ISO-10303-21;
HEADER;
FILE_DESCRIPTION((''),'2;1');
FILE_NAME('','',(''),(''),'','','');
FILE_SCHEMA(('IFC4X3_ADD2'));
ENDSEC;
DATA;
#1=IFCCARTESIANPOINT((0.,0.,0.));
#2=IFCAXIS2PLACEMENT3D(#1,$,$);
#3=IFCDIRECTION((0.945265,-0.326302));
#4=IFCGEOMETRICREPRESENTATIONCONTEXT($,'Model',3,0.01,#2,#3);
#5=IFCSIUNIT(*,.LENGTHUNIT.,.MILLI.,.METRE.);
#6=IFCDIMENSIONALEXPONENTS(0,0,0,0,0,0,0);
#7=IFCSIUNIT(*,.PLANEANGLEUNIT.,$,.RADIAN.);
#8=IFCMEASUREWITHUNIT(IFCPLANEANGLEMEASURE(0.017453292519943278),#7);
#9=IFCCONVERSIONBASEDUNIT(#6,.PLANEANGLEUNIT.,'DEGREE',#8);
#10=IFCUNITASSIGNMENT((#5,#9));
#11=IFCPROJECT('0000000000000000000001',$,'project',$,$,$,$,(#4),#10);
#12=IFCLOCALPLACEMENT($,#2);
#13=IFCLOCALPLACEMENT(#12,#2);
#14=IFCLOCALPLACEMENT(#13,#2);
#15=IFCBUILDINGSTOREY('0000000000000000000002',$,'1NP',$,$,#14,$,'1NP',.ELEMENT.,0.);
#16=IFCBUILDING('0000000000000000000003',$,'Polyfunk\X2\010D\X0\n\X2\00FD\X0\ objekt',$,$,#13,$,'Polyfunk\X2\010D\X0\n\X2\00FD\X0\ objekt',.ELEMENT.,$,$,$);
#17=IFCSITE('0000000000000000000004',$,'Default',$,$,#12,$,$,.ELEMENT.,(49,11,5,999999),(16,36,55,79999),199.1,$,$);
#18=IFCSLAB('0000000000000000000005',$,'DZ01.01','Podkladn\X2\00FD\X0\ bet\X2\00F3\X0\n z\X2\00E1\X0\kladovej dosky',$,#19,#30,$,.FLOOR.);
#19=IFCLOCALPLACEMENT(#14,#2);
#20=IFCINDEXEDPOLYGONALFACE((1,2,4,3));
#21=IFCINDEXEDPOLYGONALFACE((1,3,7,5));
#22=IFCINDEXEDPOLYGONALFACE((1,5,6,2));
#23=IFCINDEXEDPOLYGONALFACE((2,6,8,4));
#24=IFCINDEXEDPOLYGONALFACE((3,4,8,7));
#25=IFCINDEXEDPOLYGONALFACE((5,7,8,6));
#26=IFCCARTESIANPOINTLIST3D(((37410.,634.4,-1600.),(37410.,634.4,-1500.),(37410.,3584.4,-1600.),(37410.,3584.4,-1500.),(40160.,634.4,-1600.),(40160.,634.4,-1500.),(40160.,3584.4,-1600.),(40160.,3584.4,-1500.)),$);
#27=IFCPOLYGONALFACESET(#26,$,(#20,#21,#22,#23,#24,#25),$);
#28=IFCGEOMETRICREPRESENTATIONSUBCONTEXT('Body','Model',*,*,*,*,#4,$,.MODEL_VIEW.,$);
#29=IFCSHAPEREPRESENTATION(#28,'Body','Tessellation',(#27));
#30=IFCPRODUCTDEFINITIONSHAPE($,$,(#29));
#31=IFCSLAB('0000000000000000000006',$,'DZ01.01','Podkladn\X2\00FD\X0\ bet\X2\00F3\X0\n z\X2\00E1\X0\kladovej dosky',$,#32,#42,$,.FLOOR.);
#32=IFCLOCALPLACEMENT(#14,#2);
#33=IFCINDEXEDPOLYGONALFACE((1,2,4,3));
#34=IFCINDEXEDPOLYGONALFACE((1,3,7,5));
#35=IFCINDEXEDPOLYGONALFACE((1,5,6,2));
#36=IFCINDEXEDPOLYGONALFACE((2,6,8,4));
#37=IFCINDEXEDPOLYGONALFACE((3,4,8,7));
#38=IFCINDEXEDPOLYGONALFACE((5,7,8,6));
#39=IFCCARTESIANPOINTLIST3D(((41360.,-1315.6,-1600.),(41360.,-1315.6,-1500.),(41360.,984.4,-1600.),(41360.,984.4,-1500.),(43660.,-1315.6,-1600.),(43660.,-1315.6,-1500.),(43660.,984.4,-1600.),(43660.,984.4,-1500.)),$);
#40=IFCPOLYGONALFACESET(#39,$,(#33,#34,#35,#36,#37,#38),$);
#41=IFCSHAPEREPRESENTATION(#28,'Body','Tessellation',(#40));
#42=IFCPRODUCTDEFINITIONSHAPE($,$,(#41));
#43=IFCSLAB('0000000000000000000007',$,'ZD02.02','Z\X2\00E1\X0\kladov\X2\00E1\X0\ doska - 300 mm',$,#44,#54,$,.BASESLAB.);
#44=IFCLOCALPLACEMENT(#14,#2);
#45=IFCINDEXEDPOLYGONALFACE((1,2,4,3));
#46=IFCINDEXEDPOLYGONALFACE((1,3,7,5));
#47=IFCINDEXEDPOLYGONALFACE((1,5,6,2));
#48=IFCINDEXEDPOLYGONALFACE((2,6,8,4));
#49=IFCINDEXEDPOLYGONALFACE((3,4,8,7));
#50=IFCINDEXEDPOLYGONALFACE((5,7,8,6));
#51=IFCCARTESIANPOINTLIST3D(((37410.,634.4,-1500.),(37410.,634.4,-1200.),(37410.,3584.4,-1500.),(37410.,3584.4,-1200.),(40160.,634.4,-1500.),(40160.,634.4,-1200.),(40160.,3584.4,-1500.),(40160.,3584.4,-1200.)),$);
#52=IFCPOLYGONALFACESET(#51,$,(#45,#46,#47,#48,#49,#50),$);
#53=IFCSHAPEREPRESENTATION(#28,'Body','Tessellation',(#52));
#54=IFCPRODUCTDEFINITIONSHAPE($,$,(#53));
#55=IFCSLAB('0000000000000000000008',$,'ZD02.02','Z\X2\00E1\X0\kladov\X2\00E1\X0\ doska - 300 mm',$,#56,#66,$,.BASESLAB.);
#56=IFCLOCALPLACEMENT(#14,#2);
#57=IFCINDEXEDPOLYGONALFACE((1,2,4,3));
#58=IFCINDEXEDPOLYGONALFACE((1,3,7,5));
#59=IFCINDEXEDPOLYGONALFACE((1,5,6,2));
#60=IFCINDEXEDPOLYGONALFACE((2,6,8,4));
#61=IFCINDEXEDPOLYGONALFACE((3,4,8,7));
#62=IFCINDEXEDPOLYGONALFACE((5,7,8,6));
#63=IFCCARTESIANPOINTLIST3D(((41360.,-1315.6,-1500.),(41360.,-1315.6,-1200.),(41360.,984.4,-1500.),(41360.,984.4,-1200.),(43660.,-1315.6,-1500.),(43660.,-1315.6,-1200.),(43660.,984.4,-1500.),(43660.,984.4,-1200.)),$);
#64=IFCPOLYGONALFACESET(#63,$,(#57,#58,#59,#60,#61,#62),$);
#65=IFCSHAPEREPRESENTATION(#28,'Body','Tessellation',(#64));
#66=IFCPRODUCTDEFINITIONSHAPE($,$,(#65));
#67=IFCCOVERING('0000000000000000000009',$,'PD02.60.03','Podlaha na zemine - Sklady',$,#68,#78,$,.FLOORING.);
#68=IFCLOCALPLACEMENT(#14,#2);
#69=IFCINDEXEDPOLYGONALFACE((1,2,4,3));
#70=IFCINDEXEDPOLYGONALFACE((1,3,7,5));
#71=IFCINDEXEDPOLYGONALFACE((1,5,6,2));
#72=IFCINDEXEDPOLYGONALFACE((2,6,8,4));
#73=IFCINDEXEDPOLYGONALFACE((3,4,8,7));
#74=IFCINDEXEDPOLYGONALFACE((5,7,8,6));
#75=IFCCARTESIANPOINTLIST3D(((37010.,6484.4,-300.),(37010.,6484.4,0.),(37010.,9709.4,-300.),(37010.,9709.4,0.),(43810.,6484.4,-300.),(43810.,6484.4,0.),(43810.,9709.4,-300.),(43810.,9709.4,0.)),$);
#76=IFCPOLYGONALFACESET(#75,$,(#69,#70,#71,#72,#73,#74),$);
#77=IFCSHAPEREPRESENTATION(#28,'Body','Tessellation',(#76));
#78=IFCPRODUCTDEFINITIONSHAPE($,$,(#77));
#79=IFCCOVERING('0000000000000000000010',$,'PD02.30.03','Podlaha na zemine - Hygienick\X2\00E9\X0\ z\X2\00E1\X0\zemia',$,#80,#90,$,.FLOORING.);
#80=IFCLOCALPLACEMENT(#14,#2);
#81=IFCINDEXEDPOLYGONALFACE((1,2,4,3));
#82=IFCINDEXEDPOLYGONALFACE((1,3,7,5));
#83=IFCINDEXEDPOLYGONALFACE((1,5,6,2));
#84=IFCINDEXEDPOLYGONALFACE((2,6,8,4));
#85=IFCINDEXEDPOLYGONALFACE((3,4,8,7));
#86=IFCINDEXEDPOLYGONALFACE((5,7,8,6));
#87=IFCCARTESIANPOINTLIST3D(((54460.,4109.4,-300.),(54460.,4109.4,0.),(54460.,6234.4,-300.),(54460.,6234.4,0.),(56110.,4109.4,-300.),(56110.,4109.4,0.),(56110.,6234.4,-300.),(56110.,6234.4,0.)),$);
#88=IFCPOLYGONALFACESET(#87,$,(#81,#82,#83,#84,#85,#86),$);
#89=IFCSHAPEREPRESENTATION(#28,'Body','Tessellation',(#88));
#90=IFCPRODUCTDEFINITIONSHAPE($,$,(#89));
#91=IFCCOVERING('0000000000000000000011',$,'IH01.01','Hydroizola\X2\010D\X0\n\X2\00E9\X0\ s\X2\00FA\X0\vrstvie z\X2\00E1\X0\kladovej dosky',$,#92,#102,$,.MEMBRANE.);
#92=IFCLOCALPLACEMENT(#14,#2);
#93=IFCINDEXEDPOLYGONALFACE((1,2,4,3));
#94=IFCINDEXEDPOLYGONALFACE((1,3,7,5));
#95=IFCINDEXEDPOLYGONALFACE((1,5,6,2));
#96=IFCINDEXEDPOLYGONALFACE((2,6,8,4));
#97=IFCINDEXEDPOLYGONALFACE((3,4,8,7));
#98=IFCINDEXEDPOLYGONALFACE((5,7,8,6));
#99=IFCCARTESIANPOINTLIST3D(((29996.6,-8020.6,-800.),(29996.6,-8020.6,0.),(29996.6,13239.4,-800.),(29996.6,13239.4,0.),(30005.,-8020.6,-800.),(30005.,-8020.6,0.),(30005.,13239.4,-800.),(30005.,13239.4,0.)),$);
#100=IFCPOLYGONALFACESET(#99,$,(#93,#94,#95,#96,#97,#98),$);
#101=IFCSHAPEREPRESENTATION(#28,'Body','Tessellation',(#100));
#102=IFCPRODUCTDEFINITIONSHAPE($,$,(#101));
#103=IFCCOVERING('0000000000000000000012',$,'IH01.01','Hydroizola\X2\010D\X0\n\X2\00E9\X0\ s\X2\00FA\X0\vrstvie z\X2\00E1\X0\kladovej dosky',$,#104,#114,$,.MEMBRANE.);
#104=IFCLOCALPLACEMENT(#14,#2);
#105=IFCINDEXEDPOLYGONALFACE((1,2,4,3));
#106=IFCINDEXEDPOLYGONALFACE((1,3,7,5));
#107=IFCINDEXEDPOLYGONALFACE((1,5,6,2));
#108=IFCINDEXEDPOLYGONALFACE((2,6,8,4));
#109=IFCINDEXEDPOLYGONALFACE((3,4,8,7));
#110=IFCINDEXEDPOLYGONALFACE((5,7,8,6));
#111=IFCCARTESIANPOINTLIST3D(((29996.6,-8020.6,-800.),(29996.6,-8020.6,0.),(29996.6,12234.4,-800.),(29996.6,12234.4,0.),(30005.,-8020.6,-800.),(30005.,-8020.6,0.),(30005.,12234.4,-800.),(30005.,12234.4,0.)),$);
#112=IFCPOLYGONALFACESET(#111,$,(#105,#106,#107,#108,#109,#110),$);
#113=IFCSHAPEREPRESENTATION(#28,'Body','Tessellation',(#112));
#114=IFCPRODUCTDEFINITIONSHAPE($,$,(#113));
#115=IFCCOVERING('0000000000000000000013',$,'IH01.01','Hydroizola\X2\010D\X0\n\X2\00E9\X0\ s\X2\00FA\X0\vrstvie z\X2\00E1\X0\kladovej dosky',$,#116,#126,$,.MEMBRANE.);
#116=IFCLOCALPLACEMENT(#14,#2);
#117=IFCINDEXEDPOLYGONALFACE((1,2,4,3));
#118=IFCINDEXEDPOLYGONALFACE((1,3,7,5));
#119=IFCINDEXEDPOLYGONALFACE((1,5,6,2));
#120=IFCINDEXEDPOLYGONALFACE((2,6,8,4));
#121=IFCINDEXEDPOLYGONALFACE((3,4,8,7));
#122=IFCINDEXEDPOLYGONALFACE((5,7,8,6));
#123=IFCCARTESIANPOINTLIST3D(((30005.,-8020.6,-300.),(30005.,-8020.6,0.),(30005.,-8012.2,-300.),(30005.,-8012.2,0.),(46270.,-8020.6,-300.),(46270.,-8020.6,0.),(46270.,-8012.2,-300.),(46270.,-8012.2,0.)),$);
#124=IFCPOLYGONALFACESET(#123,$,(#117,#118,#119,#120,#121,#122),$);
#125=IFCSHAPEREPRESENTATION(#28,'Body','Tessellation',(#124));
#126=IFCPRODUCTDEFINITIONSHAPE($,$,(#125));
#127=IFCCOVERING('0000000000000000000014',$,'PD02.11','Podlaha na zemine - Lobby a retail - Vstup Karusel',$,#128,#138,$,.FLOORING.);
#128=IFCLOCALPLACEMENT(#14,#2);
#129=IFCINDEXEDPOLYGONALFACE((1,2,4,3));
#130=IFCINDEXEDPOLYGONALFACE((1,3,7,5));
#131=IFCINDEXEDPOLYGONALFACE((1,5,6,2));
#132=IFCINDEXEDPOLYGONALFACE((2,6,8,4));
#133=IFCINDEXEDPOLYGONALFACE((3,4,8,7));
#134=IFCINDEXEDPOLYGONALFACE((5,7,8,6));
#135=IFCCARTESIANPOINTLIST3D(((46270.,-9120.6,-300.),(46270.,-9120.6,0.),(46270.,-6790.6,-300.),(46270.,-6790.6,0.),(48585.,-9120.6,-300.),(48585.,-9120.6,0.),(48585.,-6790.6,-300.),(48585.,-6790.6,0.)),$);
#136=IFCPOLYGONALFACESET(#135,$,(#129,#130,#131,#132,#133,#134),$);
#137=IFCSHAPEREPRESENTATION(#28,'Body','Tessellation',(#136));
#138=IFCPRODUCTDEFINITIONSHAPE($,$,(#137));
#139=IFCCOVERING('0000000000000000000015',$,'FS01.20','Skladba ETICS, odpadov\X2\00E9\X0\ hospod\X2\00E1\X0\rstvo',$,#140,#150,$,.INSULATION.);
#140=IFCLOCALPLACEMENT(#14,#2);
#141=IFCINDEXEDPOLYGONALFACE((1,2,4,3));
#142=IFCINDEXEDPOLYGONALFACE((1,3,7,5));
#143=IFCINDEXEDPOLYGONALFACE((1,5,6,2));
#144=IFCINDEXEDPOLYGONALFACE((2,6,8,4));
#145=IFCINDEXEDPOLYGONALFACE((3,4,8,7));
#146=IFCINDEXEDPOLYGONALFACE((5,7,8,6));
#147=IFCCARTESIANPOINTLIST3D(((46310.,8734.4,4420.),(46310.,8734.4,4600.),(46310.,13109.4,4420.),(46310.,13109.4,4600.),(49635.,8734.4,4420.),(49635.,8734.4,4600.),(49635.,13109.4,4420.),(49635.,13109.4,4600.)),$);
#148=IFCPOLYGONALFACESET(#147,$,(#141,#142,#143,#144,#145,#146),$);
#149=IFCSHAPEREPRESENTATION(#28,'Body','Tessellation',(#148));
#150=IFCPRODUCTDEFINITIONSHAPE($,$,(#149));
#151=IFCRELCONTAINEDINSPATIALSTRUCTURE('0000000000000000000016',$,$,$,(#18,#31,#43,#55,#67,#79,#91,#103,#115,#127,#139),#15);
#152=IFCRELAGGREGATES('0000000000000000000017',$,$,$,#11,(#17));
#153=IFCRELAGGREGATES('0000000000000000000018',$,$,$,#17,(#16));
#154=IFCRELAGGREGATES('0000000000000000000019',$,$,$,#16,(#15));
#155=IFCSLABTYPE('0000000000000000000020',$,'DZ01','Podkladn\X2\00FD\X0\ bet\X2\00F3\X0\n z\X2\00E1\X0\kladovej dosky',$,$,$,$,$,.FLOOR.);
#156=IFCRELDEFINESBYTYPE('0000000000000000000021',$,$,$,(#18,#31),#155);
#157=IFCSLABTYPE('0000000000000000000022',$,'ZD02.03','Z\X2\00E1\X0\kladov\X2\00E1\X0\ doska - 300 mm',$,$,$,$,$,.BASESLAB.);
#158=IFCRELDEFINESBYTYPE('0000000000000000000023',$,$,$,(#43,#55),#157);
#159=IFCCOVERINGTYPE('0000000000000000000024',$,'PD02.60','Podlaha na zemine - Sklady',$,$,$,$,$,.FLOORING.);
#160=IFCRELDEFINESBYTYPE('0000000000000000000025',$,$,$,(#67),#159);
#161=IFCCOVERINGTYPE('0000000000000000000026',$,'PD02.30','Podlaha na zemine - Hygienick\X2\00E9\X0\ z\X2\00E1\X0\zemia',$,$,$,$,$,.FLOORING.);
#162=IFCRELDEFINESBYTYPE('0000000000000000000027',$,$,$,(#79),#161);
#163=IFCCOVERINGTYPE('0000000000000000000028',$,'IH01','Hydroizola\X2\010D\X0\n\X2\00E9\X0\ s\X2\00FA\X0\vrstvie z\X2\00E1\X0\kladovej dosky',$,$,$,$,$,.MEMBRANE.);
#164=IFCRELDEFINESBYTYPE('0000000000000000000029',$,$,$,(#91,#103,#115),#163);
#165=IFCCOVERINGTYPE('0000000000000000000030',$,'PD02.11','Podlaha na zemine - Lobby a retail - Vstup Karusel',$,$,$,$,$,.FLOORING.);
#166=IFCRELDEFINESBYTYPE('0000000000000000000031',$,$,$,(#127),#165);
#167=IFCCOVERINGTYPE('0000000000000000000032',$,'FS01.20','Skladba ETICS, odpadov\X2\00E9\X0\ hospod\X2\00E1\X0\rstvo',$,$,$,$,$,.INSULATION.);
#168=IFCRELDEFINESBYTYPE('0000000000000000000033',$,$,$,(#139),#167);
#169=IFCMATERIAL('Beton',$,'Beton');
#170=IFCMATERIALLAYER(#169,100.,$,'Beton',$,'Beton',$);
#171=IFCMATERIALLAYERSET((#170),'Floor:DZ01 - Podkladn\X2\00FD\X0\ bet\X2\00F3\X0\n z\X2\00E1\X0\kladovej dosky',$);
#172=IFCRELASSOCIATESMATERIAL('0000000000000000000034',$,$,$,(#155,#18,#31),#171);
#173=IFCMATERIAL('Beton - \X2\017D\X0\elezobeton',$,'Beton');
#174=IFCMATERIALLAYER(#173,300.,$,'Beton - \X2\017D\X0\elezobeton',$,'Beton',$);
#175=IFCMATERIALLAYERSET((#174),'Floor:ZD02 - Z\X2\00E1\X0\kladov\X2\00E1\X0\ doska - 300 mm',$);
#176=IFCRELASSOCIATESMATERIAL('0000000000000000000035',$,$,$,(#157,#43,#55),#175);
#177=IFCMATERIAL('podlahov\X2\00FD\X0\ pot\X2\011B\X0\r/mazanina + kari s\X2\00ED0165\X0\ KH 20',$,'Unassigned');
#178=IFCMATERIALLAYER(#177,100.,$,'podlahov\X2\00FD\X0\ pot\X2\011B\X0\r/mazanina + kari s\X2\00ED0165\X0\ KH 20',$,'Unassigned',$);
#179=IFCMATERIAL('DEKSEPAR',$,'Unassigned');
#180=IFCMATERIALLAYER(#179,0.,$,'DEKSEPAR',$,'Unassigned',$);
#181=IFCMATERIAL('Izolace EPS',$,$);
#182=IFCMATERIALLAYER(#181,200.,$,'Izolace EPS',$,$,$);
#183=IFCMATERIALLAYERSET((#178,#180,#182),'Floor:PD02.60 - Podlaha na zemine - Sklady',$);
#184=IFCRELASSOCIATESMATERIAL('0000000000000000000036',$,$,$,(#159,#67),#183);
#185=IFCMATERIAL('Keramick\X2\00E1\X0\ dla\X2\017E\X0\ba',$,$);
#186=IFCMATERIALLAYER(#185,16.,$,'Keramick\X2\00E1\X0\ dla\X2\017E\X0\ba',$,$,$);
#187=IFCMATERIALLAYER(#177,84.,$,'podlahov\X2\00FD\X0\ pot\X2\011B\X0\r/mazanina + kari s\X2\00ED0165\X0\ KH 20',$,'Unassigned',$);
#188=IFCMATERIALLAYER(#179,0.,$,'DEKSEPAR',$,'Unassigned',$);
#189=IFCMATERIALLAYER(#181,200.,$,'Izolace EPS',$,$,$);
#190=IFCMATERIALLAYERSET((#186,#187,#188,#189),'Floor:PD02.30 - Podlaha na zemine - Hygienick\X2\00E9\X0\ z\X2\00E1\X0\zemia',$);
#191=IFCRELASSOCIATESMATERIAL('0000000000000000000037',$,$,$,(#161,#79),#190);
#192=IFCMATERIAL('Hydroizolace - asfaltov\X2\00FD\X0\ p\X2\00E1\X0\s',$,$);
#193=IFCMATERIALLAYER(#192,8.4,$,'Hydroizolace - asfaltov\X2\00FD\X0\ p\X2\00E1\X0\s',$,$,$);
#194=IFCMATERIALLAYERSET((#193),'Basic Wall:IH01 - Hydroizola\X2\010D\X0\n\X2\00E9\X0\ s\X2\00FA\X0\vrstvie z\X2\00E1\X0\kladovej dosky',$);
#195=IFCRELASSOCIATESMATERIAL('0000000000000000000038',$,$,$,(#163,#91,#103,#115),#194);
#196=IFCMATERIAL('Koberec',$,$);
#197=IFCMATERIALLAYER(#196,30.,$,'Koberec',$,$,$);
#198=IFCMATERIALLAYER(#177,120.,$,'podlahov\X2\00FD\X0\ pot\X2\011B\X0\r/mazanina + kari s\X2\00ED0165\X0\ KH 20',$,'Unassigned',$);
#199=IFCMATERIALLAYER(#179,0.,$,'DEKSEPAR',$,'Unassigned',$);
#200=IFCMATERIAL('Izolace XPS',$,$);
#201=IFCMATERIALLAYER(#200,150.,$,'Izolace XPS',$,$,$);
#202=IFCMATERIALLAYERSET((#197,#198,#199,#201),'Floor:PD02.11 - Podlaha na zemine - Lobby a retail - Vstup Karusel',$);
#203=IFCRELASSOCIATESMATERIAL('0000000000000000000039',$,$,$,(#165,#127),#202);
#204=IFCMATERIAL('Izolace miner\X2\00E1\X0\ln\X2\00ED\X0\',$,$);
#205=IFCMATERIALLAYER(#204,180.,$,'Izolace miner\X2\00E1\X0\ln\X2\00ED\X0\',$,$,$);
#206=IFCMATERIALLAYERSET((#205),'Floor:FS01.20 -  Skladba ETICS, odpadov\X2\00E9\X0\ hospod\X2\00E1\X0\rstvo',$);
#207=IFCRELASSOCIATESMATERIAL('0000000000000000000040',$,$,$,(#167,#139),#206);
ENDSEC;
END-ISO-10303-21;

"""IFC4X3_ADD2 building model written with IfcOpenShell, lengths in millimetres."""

from ifc_helpers import new_model, entity, si_unit, converted_unit, direction, frame, frame_2d, origin, origin_2d_with_axis, place, context, subcontext, project, spatial, rectangle, extrude, material, layer, layer_set, layer_usage, type_object, element, save


model = new_model("IFC4X3_ADD2")

# Units and contexts
model_context = context("Model", 3, precision=0.01, world=origin(), true_north=direction((0.945265, -0.326302)))
body_context = subcontext(model_context, "Body", "Model", "MODEL_VIEW")
ifc_project = project(units=[si_unit("LENGTHUNIT", "METRE", prefix="MILLI"), converted_unit("PLANEANGLEUNIT", "DEGREE", entity("IfcPlaneAngleMeasure", 0.017453292519943278), si_unit("PLANEANGLEUNIT", "RADIAN"), dimensions=[0, 0, 0, 0, 0, 0, 0])], contexts=[model_context])

# Site, building, storey
site_placement = place(None, origin())
site = spatial("IfcSite", under=ifc_project, at=site_placement, Name="Default", CompositionType="ELEMENT", RefLatitude=(49, 11, 5, 999999), RefLongitude=(16, 36, 55, 79999), RefElevation=199.1)
building_placement = place(site_placement, origin())
building = spatial("IfcBuilding", under=site, at=building_placement, Name="Polyfunkčný objekt", LongName="Polyfunkčný objekt", CompositionType="ELEMENT")
storey_placement = place(building_placement, origin())
storey = spatial("IfcBuildingStorey", under=building, at=storey_placement, Name="1NP", LongName="1NP", CompositionType="ELEMENT", Elevation=0.0)

# Shared definitions
ifc_material_1 = material(Name="Beton", Category="Beton")
ifc_layer_1 = layer(ifc_material_1, 100.0, Name="Beton", Category="Beton")
ifc_layer_set_1 = layer_set([ifc_layer_1], Name="Floor:DZ01 - Podkladný betón základovej dosky")
slab_type_1 = type_object("IfcSlabType", Name="DZ01", Description="Podkladný betón základovej dosky", PredefinedType="FLOOR", material=ifc_layer_set_1)

# Slabs
ifc_layer_usage_1 = layer_usage(ifc_layer_set_1, "AXIS3", "POSITIVE", 0.0)
slab_1_placement = place(storey_placement, origin())
element("IfcSlab", 1, at=slab_1_placement, inside=storey, type_object=slab_type_1, material=ifc_layer_usage_1, Name="DZ01.01", Description="Podkladný betón základovej dosky", PredefinedType="FLOOR", context=body_context, shape_type="SweptSolid", body=[
    extrude(rectangle(XDim=2950.0, YDim=2750.0, at=frame_2d((0.0, 0.0), x_axis=(1.0, 0.0))), frame((38785.0, 2109.4, -1500.0), z_axis=(0.0, 0.0, -1.0), x_axis=(0.0, 1.0, 0.0)), (0.0, 0.0, 1.0), 100.0),
])
ifc_layer_usage_2 = layer_usage(ifc_layer_set_1, "AXIS3", "POSITIVE", 0.0)
slab_2_placement = place(storey_placement, origin())
element("IfcSlab", 2, at=slab_2_placement, inside=storey, type_object=slab_type_1, material=ifc_layer_usage_2, Name="DZ01.01", Description="Podkladný betón základovej dosky", PredefinedType="FLOOR", context=body_context, shape_type="SweptSolid", body=[
    extrude(rectangle(XDim=2300.0, YDim=2300.0, at=frame_2d((0.0, 0.0), x_axis=(1.0, 0.0))), frame((42510.0, -165.6, -1500.0), z_axis=(0.0, 0.0, -1.0), x_axis=(0.0, 1.0, 0.0)), (0.0, 0.0, 1.0), 100.0),
])
ifc_material_2 = material(Name="Beton - Železobeton", Category="Beton")
ifc_layer_2 = layer(ifc_material_2, 300.0, Name="Beton - Železobeton", Category="Beton")
ifc_layer_set_2 = layer_set([ifc_layer_2], Name="Floor:ZD02 - Základová doska - 300 mm")
ifc_layer_usage_3 = layer_usage(ifc_layer_set_2, "AXIS3", "POSITIVE", 0.0)
slab_type_2 = type_object("IfcSlabType", Name="ZD02.03", Description="Základová doska - 300 mm", PredefinedType="BASESLAB", material=ifc_layer_set_2)
slab_3_placement = place(storey_placement, origin())
element("IfcSlab", 3, at=slab_3_placement, inside=storey, type_object=slab_type_2, material=ifc_layer_usage_3, Name="ZD02.02", Description="Základová doska - 300 mm", PredefinedType="BASESLAB", context=body_context, shape_type="SweptSolid", body=[
    extrude(rectangle(XDim=2950.0, YDim=2750.0, at=frame_2d((0.0, 0.0), x_axis=(1.0, 0.0))), frame((38785.0, 2109.4, -1200.0), z_axis=(0.0, 0.0, -1.0), x_axis=(0.0, 1.0, 0.0)), (0.0, 0.0, 1.0), 300.0),
])
ifc_layer_usage_4 = layer_usage(ifc_layer_set_2, "AXIS3", "POSITIVE", 0.0)
slab_4_placement = place(storey_placement, origin())
element("IfcSlab", 4, at=slab_4_placement, inside=storey, type_object=slab_type_2, material=ifc_layer_usage_4, Name="ZD02.02", Description="Základová doska - 300 mm", PredefinedType="BASESLAB", context=body_context, shape_type="SweptSolid", body=[
    extrude(rectangle(XDim=2300.0, YDim=2300.0, at=frame_2d((0.0, 0.0), x_axis=(1.0, 0.0))), frame((42510.0, -165.6, -1200.0), z_axis=(0.0, 0.0, -1.0), x_axis=(0.0, 1.0, 0.0)), (0.0, 0.0, 1.0), 300.0),
])

# Coverings
ifc_material_3 = material(Name="podlahový potěr/mazanina + kari síť KH 20", Category="Unassigned")
ifc_layer_3 = layer(ifc_material_3, 100.0, Name="podlahový potěr/mazanina + kari síť KH 20", Category="Unassigned")
ifc_material_4 = material(Name="DEKSEPAR", Category="Unassigned")
ifc_layer_4 = layer(ifc_material_4, 0.0, Name="DEKSEPAR", Category="Unassigned")
ifc_material_5 = material(Name="Izolace EPS")
ifc_layer_5 = layer(ifc_material_5, 200.0, Name="Izolace EPS")
ifc_layer_set_3 = layer_set([ifc_layer_3, ifc_layer_4, ifc_layer_5], Name="Floor:PD02.60 - Podlaha na zemine - Sklady")
ifc_layer_usage_5 = layer_usage(ifc_layer_set_3, "AXIS3", "POSITIVE", 0.0)
covering_type_1 = type_object("IfcCoveringType", Name="PD02.60", Description="Podlaha na zemine - Sklady", PredefinedType="FLOORING", material=ifc_layer_set_3)
covering_1_placement = place(storey_placement, origin())
element("IfcCovering", 5, at=covering_1_placement, inside=storey, type_object=covering_type_1, material=ifc_layer_usage_5, Name="PD02.60.03", Description="Podlaha na zemine - Sklady", PredefinedType="FLOORING", context=body_context, shape_type="SweptSolid", body=[
    extrude(rectangle(XDim=3225.0, YDim=6800.0, at=origin_2d_with_axis()), frame((40410.0, 8096.9, 0.0), z_axis=(0.0, 0.0, -1.0), x_axis=(0.0, 1.0, 0.0)), (0.0, 0.0, 1.0), 300.0),
])
ifc_material_6 = material(Name="Keramická dlažba")
ifc_layer_6 = layer(ifc_material_6, 16.0, Name="Keramická dlažba")
ifc_layer_7 = layer(ifc_material_3, 84.0, Name="podlahový potěr/mazanina + kari síť KH 20", Category="Unassigned")
ifc_layer_8 = layer(ifc_material_4, 0.0, Name="DEKSEPAR", Category="Unassigned")
ifc_layer_9 = layer(ifc_material_5, 200.0, Name="Izolace EPS")
ifc_layer_set_4 = layer_set([ifc_layer_6, ifc_layer_7, ifc_layer_8, ifc_layer_9], Name="Floor:PD02.30 - Podlaha na zemine - Hygienické zázemia")
covering_type_2 = type_object("IfcCoveringType", Name="PD02.30", Description="Podlaha na zemine - Hygienické zázemia", PredefinedType="FLOORING", material=ifc_layer_set_4)
ifc_layer_usage_6 = layer_usage(ifc_layer_set_4, "AXIS3", "POSITIVE", 0.0)
covering_2_placement = place(storey_placement, origin())
element("IfcCovering", 6, at=covering_2_placement, inside=storey, type_object=covering_type_2, material=ifc_layer_usage_6, Name="PD02.30.03", Description="Podlaha na zemine - Hygienické zázemia", PredefinedType="FLOORING", context=body_context, shape_type="SweptSolid", body=[
    extrude(rectangle(XDim=2125.0, YDim=1650.0, at=frame_2d((0.0, 0.0), x_axis=(1.0, 0.0))), frame((55285.0, 5171.9, 0.0), z_axis=(0.0, 0.0, -1.0), x_axis=(0.0, 1.0, 0.0)), (0.0, 0.0, 1.0), 300.0),
])
ifc_material_7 = material(Name="Hydroizolace - asfaltový pás")
ifc_layer_10 = layer(ifc_material_7, 8.4, Name="Hydroizolace - asfaltový pás")
ifc_layer_set_5 = layer_set([ifc_layer_10], Name="Basic Wall:IH01 - Hydroizolačné súvrstvie základovej dosky")
covering_type_3 = type_object("IfcCoveringType", Name="IH01", Description="Hydroizolačné súvrstvie základovej dosky", PredefinedType="MEMBRANE", material=ifc_layer_set_5)
covering_3_placement = place(storey_placement, frame((30000.8, -8020.6, -800.0), z_axis=(0.0, 0.0, 1.0), x_axis=(0.0, 1.0, 0.0)))
element("IfcCovering", 7, at=covering_3_placement, inside=storey, type_object=covering_type_3, material=ifc_layer_set_5, Name="IH01.01", Description="Hydroizolačné súvrstvie základovej dosky", PredefinedType="MEMBRANE", context=body_context, shape_type="SweptSolid", body=[
    extrude(rectangle(XDim=21260.0, YDim=8.4, at=frame_2d((10630.0, 0.0), x_axis=(-1.0, 0.0))), origin(), (0.0, 0.0, 1.0), 800.0),
])
covering_4_placement = place(storey_placement, frame((30000.8, -8020.6, -800.0), z_axis=(0.0, 0.0, 1.0), x_axis=(0.0, 1.0, 0.0)))
element("IfcCovering", 8, at=covering_4_placement, inside=storey, type_object=covering_type_3, material=ifc_layer_set_5, Name="IH01.01", Description="Hydroizolačné súvrstvie základovej dosky", PredefinedType="MEMBRANE", context=body_context, shape_type="SweptSolid", body=[
    extrude(rectangle(XDim=20255.0, YDim=8.4, at=frame_2d((10127.5, 0.0), x_axis=(-1.0, 0.0))), origin(), (0.0, 0.0, 1.0), 800.0),
])
covering_5_placement = place(storey_placement, frame((30005.0, -8016.4, -300.0)))
element("IfcCovering", 9, at=covering_5_placement, inside=storey, type_object=covering_type_3, material=ifc_layer_set_5, Name="IH01.01", Description="Hydroizolačné súvrstvie základovej dosky", PredefinedType="MEMBRANE", context=body_context, shape_type="SweptSolid", body=[
    extrude(rectangle(XDim=16265.0, YDim=8.4, at=frame_2d((8132.5, 0.0), x_axis=(-1.0, 0.0))), origin(), (0.0, 0.0, 1.0), 300.0),
])
ifc_material_8 = material(Name="Koberec")
ifc_layer_11 = layer(ifc_material_8, 30.0, Name="Koberec")
ifc_layer_12 = layer(ifc_material_3, 120.0, Name="podlahový potěr/mazanina + kari síť KH 20", Category="Unassigned")
ifc_layer_13 = layer(ifc_material_4, 0.0, Name="DEKSEPAR", Category="Unassigned")
ifc_material_9 = material(Name="Izolace XPS")
ifc_layer_14 = layer(ifc_material_9, 150.0, Name="Izolace XPS")
ifc_layer_set_6 = layer_set([ifc_layer_11, ifc_layer_12, ifc_layer_13, ifc_layer_14], Name="Floor:PD02.11 - Podlaha na zemine - Lobby a retail - Vstup Karusel")
ifc_layer_usage_7 = layer_usage(ifc_layer_set_6, "AXIS3", "POSITIVE", 0.0)
covering_type_4 = type_object("IfcCoveringType", Name="PD02.11", Description="Podlaha na zemine - Lobby a retail - Vstup Karusel", PredefinedType="FLOORING", material=ifc_layer_set_6)
covering_6_placement = place(storey_placement, origin())
element("IfcCovering", 10, at=covering_6_placement, inside=storey, type_object=covering_type_4, material=ifc_layer_usage_7, Name="PD02.11", Description="Podlaha na zemine - Lobby a retail - Vstup Karusel", PredefinedType="FLOORING", context=body_context, shape_type="SweptSolid", body=[
    extrude(rectangle(XDim=2330.0, YDim=2315.0, at=frame_2d((0.0, 0.0), x_axis=(1.0, 0.0))), frame((47427.5, -7955.6, 0.0), z_axis=(0.0, 0.0, -1.0), x_axis=(0.0, 1.0, 0.0)), (0.0, 0.0, 1.0), 300.0),
])
ifc_material_10 = material(Name="Izolace minerální")
ifc_layer_15 = layer(ifc_material_10, 180.0, Name="Izolace minerální")
ifc_layer_set_7 = layer_set([ifc_layer_15], Name="Floor:FS01.20 -  Skladba ETICS, odpadové hospodárstvo")
ifc_layer_usage_8 = layer_usage(ifc_layer_set_7, "AXIS3", "POSITIVE", 0.0)
covering_type_5 = type_object("IfcCoveringType", Name="FS01.20", Description="Skladba ETICS, odpadové hospodárstvo", PredefinedType="INSULATION", material=ifc_layer_set_7)
covering_7_placement = place(storey_placement, origin())
element("IfcCovering", 11, at=covering_7_placement, inside=storey, type_object=covering_type_5, material=ifc_layer_usage_8, Name="FS01.20", Description="Skladba ETICS, odpadové hospodárstvo", PredefinedType="INSULATION", context=body_context, shape_type="SweptSolid", body=[
    extrude(rectangle(XDim=4375.0, YDim=3325.0, at=frame_2d((0.0, 0.0), x_axis=(1.0, 0.0))), frame((47972.5, 10921.9, 4600.0), z_axis=(0.0, 0.0, -1.0), x_axis=(0.0, 1.0, 0.0)), (0.0, 0.0, 1.0), 180.0),
])

save(model, "model.ifc")
